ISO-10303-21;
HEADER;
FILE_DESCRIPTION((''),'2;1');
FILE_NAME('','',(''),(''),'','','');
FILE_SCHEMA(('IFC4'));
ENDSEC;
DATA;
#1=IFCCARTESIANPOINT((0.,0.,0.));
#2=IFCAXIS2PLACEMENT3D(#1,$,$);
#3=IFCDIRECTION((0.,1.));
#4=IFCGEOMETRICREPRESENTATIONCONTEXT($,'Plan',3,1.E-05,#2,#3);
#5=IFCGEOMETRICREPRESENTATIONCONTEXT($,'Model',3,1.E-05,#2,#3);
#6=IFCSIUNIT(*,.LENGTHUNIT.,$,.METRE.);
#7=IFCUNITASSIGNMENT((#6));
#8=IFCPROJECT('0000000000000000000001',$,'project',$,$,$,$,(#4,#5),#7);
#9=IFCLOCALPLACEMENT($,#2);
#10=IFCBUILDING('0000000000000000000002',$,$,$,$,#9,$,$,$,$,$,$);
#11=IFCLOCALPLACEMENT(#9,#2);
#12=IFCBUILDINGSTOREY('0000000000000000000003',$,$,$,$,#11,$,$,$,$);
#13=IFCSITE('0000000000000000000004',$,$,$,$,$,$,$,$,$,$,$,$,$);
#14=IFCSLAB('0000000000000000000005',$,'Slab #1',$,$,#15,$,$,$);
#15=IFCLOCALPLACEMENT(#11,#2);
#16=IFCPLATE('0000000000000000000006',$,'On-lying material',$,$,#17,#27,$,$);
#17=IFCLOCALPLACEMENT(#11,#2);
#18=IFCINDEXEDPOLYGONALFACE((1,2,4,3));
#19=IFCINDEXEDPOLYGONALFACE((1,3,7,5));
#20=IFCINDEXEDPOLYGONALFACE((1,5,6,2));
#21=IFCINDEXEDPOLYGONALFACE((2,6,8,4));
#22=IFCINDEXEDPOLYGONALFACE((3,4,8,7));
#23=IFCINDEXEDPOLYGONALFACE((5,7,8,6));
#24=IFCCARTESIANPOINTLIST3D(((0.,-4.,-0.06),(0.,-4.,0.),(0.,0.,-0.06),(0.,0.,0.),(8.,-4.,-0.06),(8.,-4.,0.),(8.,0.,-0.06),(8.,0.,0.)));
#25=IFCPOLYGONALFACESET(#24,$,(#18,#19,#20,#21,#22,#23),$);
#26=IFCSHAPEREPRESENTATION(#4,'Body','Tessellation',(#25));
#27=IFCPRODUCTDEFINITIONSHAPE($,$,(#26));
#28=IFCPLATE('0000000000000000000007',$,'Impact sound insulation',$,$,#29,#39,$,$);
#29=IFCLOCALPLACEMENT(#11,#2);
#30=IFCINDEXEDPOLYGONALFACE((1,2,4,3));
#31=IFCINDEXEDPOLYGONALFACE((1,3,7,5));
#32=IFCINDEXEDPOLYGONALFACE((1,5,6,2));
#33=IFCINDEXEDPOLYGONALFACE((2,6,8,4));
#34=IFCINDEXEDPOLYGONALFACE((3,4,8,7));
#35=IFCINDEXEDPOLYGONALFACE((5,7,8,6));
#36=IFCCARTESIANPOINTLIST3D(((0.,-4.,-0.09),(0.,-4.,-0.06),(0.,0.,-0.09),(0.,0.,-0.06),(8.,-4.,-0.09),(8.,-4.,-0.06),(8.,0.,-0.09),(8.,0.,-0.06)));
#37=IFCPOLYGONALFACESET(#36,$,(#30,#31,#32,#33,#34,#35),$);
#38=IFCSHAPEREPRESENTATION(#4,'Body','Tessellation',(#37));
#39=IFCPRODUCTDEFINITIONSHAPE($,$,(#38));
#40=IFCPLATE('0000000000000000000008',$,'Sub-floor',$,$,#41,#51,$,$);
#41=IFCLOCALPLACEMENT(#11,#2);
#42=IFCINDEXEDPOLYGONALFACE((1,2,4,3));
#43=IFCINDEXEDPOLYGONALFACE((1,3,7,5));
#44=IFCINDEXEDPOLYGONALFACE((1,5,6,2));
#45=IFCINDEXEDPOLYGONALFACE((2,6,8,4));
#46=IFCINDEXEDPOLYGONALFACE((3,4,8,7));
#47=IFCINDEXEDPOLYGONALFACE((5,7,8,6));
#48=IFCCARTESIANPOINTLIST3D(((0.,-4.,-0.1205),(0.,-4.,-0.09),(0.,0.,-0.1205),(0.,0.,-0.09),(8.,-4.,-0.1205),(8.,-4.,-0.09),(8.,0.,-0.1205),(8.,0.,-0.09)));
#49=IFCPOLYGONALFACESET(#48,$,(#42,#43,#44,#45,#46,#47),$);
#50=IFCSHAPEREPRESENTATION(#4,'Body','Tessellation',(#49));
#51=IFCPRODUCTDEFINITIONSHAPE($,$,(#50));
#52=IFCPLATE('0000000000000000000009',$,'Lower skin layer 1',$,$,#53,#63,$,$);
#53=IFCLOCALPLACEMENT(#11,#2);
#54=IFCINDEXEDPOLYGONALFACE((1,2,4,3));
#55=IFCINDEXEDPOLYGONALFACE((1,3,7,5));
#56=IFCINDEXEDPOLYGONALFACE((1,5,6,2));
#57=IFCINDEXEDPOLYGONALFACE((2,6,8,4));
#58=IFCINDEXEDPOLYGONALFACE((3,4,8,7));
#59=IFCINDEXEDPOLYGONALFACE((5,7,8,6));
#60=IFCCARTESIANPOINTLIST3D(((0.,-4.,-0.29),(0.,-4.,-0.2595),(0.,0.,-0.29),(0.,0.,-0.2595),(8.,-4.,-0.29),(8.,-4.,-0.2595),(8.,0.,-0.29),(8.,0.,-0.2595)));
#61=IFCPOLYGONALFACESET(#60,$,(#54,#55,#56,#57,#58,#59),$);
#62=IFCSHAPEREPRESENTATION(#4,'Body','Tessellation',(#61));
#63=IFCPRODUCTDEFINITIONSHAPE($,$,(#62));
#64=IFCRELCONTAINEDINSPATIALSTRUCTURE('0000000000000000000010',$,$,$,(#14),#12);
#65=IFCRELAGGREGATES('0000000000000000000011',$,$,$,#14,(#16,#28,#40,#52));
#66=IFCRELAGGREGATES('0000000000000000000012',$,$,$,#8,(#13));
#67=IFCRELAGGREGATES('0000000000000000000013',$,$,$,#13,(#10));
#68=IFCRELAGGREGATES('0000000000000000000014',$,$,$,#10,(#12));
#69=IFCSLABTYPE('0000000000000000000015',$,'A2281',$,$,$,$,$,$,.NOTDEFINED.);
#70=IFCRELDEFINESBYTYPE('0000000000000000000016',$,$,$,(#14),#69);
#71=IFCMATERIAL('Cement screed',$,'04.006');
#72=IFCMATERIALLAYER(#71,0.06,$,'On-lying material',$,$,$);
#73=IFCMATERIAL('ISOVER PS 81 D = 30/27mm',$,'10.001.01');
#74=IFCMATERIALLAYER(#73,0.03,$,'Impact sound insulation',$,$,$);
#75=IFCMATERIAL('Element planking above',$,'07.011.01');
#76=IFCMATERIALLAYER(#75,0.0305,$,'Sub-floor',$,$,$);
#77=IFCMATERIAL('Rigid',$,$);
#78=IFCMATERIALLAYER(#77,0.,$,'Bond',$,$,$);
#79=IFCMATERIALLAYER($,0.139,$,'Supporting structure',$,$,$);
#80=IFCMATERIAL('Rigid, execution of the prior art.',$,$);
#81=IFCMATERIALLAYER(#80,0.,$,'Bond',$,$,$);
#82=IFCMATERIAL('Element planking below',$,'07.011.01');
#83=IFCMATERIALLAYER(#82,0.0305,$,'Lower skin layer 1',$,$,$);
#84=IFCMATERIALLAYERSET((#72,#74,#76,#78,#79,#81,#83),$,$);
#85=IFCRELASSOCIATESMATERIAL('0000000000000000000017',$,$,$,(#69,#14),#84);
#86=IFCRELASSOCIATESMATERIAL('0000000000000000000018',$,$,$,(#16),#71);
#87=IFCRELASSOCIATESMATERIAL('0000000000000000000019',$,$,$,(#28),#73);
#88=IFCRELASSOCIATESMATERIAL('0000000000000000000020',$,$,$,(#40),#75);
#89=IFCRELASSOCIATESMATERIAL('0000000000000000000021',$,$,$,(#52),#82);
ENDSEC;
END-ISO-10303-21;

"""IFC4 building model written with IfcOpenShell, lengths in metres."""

from ifc_helpers import new_model, si_unit, direction, frame, frame_2d, origin, origin_with_axes, place, context, project, spatial, rectangle, extrude, material, layer, layer_set, type_object, element, aggregate, save


model = new_model("IFC4")

# Units and contexts
plan_context = context("Plan", 3, precision=1e-05, world=origin(), true_north=direction((0.0, 1.0)))
model_context = context("Model", 3, precision=1e-05, world=origin(), true_north=direction((0.0, 1.0)))
ifc_project = project(units=[si_unit("LENGTHUNIT", "METRE")], contexts=[plan_context, model_context])

# Site, building, storey
site = spatial("IfcSite", under=ifc_project)
building_placement = place(None, origin())
building = spatial("IfcBuilding", under=site, at=building_placement)
storey_placement = place(building_placement, origin())
storey = spatial("IfcBuildingStorey", under=building, at=storey_placement)

# Slab, plates
ifc_material_1 = material(Name="Cement screed", Category="04.006")
ifc_layer_1 = layer(ifc_material_1, 0.06, Name="On-lying material")
ifc_material_2 = material(Name="ISOVER PS 81 D = 30/27mm", Category="10.001.01")
ifc_layer_2 = layer(ifc_material_2, 0.03, Name="Impact sound insulation")
ifc_material_3 = material(Name="Element planking above", Category="07.011.01")
ifc_layer_3 = layer(ifc_material_3, 0.0305, Name="Sub-floor")
ifc_material_4 = material(Name="Rigid")
ifc_layer_4 = layer(ifc_material_4, 0.0, Name="Bond")
ifc_layer_5 = layer(None, 0.139, Name="Supporting structure")
ifc_material_5 = material(Name="Rigid, execution of the prior art.")
ifc_layer_6 = layer(ifc_material_5, 0.0, Name="Bond")
ifc_material_6 = material(Name="Element planking below", Category="07.011.01")
ifc_layer_7 = layer(ifc_material_6, 0.0305, Name="Lower skin layer 1")
ifc_layer_set = layer_set([ifc_layer_1, ifc_layer_2, ifc_layer_3, ifc_layer_4, ifc_layer_5, ifc_layer_6, ifc_layer_7])
slab_type = type_object("IfcSlabType", Name="A2281", PredefinedType="NOTDEFINED", material=ifc_layer_set)
slab_placement = place(None, frame((0.0, 0.0, 0.0), z_axis=(0.0, 0.0, -1.0), x_axis=(1.0, 0.0, 0.0)))
slab = element("IfcSlab", 1, at=slab_placement, inside=storey, type_object=slab_type, material=ifc_layer_set, Name="Slab #1")
plate_1_placement = place(slab_placement, origin())
plate_1 = element("IfcPlate", 2, at=plate_1_placement, material=ifc_material_1, Name="On-lying material", context=plan_context, shape_type="SweptSolid", body=[
    extrude(rectangle(XDim=8.0, YDim=4.0, at=frame_2d((4.0, 2.0), x_axis=(1.0, 0.0))), origin_with_axes(), (0.0, 0.0, 1.0), 0.06),
])
plate_2_placement = place(slab_placement, origin())
plate_2 = element("IfcPlate", 3, at=plate_2_placement, material=ifc_material_2, Name="Impact sound insulation", context=plan_context, shape_type="SweptSolid", body=[
    extrude(rectangle(XDim=8.0, YDim=4.0, at=frame_2d((4.0, 2.0), x_axis=(1.0, 0.0))), frame((0.0, 0.0, 0.06), z_axis=(0.0, 0.0, 1.0), x_axis=(1.0, 0.0, 0.0)), (0.0, 0.0, 1.0), 0.03),
])
plate_3_placement = place(slab_placement, origin())
plate_3 = element("IfcPlate", 4, at=plate_3_placement, material=ifc_material_3, Name="Sub-floor", context=plan_context, shape_type="SweptSolid", body=[
    extrude(rectangle(XDim=8.0, YDim=4.0, at=frame_2d((4.0, 2.0), x_axis=(1.0, 0.0))), frame((0.0, 0.0, 0.09), z_axis=(0.0, 0.0, 1.0), x_axis=(1.0, 0.0, 0.0)), (0.0, 0.0, 1.0), 0.0305),
])
plate_4_placement = place(slab_placement, origin())
plate_4 = element("IfcPlate", 5, at=plate_4_placement, material=ifc_material_6, Name="Lower skin layer 1", context=plan_context, shape_type="SweptSolid", body=[
    extrude(rectangle(XDim=8.0, YDim=4.0, at=frame_2d((4.0, 2.0), x_axis=(1.0, 0.0))), frame((0.0, 0.0, 0.2595), z_axis=(0.0, 0.0, 1.0), x_axis=(1.0, 0.0, 0.0)), (0.0, 0.0, 1.0), 0.0305),
])
aggregate(slab, [plate_1, plate_2, plate_3, plate_4])

save(model, "model.ifc")
